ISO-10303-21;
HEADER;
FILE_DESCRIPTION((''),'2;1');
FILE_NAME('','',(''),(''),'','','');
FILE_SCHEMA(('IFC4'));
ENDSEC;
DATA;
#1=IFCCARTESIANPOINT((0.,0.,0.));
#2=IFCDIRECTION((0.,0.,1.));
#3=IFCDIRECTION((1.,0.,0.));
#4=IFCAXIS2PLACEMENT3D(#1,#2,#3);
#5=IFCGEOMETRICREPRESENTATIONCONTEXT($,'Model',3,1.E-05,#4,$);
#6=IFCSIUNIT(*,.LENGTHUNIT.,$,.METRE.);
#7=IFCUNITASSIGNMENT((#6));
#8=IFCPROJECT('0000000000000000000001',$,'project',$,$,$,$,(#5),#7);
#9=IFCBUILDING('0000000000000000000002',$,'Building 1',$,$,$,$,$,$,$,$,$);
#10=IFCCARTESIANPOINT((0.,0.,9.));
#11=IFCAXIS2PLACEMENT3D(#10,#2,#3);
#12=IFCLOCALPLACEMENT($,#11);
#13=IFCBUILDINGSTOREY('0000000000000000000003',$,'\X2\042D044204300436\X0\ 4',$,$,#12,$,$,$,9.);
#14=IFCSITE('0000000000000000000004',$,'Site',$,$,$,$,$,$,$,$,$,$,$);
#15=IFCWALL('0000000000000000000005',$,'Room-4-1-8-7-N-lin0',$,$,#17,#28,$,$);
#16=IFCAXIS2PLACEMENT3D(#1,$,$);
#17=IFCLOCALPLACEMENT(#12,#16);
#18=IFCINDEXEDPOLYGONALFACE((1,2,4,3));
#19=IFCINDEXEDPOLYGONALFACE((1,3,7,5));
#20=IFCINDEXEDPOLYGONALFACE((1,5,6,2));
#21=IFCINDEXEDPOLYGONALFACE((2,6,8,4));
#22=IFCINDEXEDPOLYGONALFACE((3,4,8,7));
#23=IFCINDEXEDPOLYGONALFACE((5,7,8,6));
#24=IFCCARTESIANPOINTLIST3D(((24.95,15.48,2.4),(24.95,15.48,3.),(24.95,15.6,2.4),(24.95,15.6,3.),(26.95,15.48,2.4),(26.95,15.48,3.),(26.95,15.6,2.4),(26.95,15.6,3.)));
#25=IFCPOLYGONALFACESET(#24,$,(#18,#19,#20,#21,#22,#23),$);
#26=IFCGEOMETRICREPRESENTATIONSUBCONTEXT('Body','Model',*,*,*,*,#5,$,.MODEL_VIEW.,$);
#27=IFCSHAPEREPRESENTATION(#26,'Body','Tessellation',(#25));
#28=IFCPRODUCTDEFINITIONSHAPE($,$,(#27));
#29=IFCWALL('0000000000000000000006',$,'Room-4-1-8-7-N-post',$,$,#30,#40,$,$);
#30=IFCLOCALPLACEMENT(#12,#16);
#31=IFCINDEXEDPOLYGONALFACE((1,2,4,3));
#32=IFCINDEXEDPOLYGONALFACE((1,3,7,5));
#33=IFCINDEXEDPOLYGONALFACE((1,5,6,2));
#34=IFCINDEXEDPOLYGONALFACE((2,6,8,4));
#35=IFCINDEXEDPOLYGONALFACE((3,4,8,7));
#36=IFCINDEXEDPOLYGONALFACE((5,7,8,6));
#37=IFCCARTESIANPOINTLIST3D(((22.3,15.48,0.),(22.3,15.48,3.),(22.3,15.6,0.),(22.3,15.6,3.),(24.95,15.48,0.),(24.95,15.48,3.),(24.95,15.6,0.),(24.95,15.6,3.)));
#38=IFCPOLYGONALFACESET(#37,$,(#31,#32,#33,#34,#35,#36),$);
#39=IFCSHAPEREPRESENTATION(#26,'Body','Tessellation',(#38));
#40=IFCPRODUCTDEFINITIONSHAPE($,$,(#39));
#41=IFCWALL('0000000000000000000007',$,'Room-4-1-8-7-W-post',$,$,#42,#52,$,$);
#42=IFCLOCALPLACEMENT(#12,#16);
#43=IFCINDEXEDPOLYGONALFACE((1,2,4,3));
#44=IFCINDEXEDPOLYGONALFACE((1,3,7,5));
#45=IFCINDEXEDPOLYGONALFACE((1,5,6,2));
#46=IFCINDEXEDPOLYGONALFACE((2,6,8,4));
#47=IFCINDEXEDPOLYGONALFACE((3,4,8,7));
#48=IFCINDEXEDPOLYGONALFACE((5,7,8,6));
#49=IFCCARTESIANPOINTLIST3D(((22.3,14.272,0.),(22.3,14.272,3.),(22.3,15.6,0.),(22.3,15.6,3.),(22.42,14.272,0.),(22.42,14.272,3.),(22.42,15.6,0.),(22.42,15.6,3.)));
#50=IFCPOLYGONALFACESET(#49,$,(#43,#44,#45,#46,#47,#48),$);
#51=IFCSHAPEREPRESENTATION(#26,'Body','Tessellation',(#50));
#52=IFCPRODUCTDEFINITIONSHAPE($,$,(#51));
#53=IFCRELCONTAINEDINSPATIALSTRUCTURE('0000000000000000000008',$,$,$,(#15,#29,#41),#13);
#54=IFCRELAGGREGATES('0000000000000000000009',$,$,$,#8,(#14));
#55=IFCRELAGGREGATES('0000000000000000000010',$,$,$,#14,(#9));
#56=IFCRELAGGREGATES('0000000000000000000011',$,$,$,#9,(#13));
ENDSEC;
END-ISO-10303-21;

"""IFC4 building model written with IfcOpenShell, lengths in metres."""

from ifc_helpers import new_model, si_unit, frame, origin_with_axes, place, context, subcontext, project, spatial, indexed_curve, outline, extrude, element, save


model = new_model("IFC4")

# Units and contexts
model_context = context("Model", 3, precision=1e-05, world=origin_with_axes())
body_context = subcontext(model_context, "Body", "Model", "MODEL_VIEW")
ifc_project = project(units=[si_unit("LENGTHUNIT", "METRE")], contexts=[model_context])

# Site, building, storey
site = spatial("IfcSite", under=ifc_project, Name="Site")
building = spatial("IfcBuilding", under=site, Name="Building 1")
storey_placement = place(None, frame((0.0, 0.0, 9.0), z_axis=(0.0, 0.0, 1.0), x_axis=(1.0, 0.0, 0.0)))
storey = spatial("IfcBuildingStorey", under=building, at=storey_placement, Name="Этаж 4", Elevation=9.0)

# Walls
wall_1_placement = place(storey_placement, frame((26.95, 15.6, 2.4), z_axis=(0.0, 0.0, 1.0), x_axis=(-1.0, 0.0, 0.0)))
element("IfcWall", 1, at=wall_1_placement, inside=storey, Name="Room-4-1-8-7-N-lin0", context=body_context, shape_type="SweptSolid", body=[
    extrude(outline(indexed_curve([(0.0, 0.0), (0.0, 0.12), (2.0, 0.12), (2.0, 0.0), (0.0, 0.0)], self_intersect=False)), origin_with_axes(), (0.0, 0.0, 1.0), 0.6),
])
wall_2_placement = place(storey_placement, frame((24.95, 15.6, 0.0), z_axis=(0.0, 0.0, 1.0), x_axis=(-1.0, 0.0, 0.0)))
element("IfcWall", 2, at=wall_2_placement, inside=storey, Name="Room-4-1-8-7-N-post", context=body_context, shape_type="SweptSolid", body=[
    extrude(outline(indexed_curve([(0.0, 0.0), (0.0, 0.12), (2.65, 0.12), (2.65, 0.0), (0.0, 0.0)], self_intersect=False)), origin_with_axes(), (0.0, 0.0, 1.0), 3.0),
])
wall_3_placement = place(storey_placement, frame((22.3, 15.6, 0.0), z_axis=(0.0, 0.0, 1.0), x_axis=(0.0, -1.0, 0.0)))
element("IfcWall", 3, at=wall_3_placement, inside=storey, Name="Room-4-1-8-7-W-post", context=body_context, shape_type="SweptSolid", body=[
    extrude(outline(indexed_curve([(0.0, 0.0), (0.0, 0.12), (1.328, 0.12), (1.328, 0.0), (0.0, 0.0)], self_intersect=False)), origin_with_axes(), (0.0, 0.0, 1.0), 3.0),
])

save(model, "model.ifc")
